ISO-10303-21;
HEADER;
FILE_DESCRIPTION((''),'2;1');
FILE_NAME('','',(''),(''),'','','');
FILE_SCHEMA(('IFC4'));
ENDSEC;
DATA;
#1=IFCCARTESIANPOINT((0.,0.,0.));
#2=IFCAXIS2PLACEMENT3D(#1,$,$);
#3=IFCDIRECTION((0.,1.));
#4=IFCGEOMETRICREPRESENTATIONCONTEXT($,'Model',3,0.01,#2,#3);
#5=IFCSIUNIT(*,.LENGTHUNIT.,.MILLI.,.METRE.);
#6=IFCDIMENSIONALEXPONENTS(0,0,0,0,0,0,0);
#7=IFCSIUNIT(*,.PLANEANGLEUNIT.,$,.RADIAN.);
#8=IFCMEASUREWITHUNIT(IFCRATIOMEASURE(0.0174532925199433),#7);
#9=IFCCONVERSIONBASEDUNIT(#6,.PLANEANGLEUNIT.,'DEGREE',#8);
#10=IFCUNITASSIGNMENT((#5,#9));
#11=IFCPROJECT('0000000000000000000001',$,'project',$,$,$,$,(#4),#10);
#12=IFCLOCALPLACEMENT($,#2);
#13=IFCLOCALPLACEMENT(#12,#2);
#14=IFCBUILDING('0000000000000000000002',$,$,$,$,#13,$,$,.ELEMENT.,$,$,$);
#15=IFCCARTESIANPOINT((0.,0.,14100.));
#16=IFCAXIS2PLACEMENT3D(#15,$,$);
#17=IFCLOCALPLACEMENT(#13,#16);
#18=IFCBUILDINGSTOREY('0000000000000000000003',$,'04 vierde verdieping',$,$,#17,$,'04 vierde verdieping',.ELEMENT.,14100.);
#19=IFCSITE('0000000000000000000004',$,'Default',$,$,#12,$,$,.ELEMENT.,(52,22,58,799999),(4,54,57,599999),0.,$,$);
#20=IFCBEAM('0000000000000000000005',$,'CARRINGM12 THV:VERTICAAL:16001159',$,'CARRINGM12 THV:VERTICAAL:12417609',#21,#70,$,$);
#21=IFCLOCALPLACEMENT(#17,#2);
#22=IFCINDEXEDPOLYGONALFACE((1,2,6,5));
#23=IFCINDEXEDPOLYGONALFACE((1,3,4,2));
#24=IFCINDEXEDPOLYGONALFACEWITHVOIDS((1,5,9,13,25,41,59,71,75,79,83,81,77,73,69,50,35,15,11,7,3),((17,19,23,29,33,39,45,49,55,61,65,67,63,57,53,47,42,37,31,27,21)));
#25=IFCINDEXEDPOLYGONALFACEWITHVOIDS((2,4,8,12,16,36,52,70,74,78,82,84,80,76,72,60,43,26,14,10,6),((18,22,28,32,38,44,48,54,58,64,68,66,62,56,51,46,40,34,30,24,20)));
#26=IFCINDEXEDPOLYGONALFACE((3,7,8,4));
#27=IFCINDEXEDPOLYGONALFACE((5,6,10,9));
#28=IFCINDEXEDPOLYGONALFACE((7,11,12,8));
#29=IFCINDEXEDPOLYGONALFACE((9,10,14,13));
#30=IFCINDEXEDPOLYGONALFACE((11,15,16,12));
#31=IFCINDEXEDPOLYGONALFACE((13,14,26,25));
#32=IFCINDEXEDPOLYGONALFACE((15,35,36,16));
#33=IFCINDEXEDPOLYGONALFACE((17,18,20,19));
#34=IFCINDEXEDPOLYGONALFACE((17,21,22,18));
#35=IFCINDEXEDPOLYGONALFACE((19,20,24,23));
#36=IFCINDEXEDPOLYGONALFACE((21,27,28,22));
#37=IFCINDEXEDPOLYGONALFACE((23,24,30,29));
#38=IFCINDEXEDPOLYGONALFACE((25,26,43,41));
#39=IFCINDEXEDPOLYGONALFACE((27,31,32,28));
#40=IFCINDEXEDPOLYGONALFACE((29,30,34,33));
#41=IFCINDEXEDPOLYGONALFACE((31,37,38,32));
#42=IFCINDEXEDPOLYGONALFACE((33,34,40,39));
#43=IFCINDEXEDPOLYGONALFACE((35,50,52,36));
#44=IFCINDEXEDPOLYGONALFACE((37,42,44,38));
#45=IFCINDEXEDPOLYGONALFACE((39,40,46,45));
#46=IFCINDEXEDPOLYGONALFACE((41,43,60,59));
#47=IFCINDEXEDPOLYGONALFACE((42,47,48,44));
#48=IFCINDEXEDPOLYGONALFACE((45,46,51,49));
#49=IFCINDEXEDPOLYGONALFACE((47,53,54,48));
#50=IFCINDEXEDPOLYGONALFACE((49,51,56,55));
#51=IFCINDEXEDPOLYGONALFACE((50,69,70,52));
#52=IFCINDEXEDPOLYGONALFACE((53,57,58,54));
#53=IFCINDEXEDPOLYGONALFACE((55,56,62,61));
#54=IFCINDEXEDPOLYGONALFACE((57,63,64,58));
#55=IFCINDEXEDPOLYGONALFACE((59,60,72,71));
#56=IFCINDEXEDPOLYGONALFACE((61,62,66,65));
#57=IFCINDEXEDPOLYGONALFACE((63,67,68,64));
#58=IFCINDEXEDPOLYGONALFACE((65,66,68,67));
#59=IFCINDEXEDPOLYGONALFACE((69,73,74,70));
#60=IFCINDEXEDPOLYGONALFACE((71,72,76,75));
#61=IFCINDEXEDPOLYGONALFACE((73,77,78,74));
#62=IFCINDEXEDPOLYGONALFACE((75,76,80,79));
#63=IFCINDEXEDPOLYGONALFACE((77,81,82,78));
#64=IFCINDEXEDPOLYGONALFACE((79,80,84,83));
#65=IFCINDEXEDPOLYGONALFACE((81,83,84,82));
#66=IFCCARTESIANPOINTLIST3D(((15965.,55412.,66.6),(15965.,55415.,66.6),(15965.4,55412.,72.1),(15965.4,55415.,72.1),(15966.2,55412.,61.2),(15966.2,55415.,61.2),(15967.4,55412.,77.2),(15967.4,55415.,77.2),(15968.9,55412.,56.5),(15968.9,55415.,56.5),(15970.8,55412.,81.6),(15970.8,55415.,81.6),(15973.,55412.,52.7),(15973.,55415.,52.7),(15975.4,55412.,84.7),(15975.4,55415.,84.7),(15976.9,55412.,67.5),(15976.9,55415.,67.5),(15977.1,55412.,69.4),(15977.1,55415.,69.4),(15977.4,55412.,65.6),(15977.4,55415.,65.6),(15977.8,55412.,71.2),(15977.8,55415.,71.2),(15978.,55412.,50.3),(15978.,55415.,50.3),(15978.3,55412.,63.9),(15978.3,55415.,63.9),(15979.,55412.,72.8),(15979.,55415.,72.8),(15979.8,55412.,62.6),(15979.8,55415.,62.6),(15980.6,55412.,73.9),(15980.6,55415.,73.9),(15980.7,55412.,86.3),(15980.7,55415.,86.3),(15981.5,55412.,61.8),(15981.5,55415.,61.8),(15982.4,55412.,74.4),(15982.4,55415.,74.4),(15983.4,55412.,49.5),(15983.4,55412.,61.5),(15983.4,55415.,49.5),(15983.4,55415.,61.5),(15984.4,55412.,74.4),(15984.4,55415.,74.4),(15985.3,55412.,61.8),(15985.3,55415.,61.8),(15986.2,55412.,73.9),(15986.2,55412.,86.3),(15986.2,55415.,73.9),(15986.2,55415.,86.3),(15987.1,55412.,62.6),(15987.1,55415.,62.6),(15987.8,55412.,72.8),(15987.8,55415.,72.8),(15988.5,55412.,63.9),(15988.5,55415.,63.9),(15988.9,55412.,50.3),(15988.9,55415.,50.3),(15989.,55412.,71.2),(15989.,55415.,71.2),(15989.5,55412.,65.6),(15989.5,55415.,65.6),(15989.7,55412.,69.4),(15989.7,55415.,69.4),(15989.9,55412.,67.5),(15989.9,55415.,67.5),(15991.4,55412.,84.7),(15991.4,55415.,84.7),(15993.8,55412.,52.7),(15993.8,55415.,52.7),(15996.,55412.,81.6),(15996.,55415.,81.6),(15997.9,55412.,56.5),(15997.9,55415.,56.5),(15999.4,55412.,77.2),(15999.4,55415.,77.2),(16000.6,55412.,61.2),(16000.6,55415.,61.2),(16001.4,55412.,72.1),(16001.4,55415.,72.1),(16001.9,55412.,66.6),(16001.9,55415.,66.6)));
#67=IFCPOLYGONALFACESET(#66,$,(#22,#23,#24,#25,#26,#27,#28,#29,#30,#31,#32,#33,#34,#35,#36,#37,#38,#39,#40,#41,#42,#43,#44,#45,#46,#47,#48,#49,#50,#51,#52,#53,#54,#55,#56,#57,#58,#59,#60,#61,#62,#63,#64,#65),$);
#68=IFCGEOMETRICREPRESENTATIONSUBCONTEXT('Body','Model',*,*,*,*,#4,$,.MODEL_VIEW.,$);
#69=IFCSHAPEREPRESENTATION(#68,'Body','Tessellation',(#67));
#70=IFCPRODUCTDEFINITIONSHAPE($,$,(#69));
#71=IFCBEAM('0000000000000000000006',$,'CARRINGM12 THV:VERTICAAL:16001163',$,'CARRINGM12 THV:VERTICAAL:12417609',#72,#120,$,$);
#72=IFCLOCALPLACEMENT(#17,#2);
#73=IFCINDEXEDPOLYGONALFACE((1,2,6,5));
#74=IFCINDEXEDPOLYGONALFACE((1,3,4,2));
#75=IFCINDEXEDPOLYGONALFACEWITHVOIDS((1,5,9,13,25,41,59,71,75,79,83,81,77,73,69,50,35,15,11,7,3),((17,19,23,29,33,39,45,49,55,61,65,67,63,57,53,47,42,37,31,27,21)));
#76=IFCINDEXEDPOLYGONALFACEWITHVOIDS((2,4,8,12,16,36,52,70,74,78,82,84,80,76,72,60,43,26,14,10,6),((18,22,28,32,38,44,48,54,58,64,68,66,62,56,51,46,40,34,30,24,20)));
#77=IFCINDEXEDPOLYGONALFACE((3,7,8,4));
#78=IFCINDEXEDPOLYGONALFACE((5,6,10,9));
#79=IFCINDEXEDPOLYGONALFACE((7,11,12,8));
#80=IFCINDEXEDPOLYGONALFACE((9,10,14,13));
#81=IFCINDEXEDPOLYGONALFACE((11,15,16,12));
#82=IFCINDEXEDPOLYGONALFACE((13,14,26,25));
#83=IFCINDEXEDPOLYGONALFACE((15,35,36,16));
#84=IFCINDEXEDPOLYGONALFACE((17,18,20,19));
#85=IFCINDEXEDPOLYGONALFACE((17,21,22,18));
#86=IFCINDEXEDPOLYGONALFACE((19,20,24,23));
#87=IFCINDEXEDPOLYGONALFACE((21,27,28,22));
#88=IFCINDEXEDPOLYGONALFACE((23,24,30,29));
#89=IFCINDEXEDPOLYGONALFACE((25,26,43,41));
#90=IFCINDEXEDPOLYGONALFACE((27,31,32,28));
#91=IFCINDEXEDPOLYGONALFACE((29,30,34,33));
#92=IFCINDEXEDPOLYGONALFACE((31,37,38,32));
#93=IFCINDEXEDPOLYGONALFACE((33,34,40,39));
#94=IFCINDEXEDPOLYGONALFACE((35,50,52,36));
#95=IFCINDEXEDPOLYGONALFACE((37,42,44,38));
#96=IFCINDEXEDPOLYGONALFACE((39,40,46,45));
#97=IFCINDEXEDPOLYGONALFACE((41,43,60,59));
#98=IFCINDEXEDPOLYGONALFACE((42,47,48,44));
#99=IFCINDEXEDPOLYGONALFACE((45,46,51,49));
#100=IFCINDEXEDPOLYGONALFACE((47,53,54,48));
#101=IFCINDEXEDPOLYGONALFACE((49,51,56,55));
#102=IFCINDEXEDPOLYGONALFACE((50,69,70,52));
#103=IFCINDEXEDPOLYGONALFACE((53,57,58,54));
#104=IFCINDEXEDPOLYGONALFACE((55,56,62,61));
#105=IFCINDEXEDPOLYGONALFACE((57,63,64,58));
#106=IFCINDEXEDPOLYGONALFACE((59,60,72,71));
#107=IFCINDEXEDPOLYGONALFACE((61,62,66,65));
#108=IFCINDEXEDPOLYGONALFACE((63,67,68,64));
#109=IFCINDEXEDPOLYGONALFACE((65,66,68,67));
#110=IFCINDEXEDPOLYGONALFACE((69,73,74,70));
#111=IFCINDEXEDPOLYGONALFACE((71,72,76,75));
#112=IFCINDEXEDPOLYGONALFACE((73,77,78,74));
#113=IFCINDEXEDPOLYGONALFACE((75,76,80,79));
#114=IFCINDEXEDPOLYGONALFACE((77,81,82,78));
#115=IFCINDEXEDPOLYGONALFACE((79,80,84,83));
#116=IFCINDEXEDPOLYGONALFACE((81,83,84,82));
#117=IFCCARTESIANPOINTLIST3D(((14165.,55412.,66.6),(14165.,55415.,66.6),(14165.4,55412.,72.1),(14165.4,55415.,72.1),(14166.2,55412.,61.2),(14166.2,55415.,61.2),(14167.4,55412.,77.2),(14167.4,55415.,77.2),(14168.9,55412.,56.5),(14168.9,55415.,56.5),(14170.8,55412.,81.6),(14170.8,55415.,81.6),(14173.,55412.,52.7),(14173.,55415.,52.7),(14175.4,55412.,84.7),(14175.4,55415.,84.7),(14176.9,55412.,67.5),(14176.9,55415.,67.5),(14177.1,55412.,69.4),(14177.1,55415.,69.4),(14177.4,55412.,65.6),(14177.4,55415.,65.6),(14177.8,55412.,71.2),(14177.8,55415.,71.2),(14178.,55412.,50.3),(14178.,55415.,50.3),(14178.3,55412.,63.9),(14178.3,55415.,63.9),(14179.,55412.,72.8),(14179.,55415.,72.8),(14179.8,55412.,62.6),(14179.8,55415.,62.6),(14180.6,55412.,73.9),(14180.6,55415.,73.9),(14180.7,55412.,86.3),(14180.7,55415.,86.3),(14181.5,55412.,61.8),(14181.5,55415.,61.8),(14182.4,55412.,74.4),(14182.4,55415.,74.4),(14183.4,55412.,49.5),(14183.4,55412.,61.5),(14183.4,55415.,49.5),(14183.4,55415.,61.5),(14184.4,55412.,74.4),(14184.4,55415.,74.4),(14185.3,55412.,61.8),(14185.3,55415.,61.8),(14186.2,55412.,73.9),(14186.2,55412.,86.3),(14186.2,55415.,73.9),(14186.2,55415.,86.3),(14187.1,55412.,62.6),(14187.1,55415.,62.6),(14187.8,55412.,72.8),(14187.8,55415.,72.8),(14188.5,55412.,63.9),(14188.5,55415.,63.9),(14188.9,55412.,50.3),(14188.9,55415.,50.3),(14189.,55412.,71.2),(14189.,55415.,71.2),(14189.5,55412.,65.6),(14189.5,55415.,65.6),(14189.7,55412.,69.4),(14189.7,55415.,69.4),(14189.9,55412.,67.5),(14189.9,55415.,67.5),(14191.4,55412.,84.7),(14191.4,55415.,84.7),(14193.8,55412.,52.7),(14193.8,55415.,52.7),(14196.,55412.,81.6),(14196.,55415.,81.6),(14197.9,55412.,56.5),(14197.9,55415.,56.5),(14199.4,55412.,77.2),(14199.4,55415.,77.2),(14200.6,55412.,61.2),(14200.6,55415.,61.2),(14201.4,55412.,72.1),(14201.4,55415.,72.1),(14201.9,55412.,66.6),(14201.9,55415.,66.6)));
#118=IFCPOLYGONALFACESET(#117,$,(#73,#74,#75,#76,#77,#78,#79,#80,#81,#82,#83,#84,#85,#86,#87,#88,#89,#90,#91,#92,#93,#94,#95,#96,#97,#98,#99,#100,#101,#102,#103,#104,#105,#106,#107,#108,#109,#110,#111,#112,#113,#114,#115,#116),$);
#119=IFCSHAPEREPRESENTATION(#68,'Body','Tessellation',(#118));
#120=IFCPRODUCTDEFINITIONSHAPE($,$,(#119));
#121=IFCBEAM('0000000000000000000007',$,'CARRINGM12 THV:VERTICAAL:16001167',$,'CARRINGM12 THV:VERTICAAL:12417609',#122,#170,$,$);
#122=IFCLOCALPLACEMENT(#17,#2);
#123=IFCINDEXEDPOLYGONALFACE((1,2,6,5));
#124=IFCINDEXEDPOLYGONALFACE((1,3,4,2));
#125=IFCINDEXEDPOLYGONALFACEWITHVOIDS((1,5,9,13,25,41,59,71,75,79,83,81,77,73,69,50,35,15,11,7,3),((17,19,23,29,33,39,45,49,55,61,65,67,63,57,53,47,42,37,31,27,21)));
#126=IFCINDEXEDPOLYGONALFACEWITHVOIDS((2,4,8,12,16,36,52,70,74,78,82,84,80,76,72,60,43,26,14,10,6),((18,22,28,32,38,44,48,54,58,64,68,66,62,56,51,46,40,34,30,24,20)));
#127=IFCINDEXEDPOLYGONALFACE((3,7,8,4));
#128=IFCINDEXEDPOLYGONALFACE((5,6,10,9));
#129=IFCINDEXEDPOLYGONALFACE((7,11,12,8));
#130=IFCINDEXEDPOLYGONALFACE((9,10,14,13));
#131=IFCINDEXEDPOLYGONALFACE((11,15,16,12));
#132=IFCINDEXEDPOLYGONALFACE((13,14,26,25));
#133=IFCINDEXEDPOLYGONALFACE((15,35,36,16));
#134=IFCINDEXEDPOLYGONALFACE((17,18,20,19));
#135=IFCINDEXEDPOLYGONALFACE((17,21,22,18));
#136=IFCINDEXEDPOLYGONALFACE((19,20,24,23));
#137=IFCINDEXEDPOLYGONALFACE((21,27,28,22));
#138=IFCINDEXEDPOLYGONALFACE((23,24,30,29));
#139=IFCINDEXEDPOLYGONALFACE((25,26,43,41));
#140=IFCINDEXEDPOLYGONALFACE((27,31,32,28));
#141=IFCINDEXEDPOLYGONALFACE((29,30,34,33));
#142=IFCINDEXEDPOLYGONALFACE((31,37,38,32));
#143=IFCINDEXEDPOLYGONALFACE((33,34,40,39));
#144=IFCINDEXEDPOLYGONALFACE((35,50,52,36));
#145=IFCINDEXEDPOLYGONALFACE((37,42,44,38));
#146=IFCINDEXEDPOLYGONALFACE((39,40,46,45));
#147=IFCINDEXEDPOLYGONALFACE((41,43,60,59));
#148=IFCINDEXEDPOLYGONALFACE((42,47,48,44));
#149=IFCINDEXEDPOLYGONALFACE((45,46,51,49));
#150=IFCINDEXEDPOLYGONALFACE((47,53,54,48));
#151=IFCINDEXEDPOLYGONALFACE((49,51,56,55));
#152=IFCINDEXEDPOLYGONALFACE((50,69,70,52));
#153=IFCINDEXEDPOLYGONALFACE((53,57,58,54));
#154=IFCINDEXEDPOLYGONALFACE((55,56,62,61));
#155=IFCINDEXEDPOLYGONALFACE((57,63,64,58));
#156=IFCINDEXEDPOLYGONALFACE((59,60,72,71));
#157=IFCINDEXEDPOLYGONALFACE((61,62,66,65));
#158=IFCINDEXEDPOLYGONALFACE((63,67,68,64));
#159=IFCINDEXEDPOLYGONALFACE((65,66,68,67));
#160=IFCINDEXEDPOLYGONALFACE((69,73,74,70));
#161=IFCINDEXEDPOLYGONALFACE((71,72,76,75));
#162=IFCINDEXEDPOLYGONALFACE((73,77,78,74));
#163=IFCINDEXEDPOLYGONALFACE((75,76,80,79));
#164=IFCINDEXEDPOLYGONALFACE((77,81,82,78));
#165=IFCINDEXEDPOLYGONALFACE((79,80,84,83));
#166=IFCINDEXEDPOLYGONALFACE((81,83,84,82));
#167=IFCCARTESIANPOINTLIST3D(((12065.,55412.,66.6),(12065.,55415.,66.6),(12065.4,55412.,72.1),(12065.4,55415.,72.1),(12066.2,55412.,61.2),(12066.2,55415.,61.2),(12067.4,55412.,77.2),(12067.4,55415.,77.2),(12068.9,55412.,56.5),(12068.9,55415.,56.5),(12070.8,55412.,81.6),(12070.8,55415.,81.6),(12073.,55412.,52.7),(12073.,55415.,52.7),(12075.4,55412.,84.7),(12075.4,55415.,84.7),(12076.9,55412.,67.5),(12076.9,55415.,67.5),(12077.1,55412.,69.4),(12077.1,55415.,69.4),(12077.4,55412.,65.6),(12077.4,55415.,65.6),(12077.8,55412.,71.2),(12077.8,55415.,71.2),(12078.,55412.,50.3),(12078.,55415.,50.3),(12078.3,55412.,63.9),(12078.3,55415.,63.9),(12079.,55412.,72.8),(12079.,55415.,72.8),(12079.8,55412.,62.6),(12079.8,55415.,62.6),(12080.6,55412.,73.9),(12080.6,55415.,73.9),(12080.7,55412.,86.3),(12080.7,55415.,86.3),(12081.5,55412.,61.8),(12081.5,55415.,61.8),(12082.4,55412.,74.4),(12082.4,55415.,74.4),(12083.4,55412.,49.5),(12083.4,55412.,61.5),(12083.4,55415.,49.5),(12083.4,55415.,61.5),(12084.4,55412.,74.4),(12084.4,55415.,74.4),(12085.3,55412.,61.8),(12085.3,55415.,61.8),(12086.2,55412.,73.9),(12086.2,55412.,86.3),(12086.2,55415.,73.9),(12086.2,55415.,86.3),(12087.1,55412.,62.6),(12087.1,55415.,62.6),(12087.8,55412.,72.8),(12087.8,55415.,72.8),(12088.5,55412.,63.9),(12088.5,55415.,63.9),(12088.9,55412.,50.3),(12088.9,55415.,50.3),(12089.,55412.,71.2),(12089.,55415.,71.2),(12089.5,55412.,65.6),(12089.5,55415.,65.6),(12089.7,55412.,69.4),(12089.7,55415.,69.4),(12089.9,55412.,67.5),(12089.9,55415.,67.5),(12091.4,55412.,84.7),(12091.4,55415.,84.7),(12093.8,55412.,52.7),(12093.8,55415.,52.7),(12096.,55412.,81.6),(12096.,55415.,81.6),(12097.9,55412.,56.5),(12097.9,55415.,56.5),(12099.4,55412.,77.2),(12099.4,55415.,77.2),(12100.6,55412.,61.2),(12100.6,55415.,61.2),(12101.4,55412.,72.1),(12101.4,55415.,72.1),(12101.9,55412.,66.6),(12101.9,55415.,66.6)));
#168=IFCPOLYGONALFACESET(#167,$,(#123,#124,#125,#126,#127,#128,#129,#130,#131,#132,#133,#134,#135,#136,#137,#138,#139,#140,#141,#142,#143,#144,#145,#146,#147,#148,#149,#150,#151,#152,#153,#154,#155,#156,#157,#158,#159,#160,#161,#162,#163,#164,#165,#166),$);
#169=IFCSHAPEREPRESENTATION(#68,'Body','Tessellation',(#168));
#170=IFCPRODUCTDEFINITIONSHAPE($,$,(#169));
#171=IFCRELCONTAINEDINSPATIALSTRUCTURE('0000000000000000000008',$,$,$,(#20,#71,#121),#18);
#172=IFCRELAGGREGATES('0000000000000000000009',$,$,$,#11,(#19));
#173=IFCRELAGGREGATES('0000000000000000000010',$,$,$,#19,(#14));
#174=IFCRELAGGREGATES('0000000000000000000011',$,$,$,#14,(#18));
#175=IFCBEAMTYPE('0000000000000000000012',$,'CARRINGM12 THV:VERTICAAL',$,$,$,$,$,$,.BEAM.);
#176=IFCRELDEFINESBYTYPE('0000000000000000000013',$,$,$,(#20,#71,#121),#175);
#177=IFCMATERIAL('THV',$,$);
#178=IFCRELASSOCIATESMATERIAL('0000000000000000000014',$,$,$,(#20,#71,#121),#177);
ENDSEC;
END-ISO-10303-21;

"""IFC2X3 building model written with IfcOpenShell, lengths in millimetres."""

from ifc_helpers import new_model, entity, si_unit, converted_unit, direction, frame, origin, origin_2d_with_axis, place, context, subcontext, project, spatial, hollow_circle, extrude, material, type_object, element, save


model = new_model("IFC2X3")

# Units and contexts
model_context = context("Model", 3, precision=0.01, world=origin(), true_north=direction((0.0, 1.0)))
body_context = subcontext(model_context, "Body", "Model", "MODEL_VIEW")
ifc_project = project(units=[si_unit("LENGTHUNIT", "METRE", prefix="MILLI"), converted_unit("PLANEANGLEUNIT", "DEGREE", entity("IfcRatioMeasure", 0.0174532925199433), si_unit("PLANEANGLEUNIT", "RADIAN"), dimensions=[0, 0, 0, 0, 0, 0, 0])], contexts=[model_context])

# Site, building, storey
site_placement = place(None, origin())
site = spatial("IfcSite", under=ifc_project, at=site_placement, Name="Default", CompositionType="ELEMENT", RefLatitude=(52, 22, 58, 799999), RefLongitude=(4, 54, 57, 599999), RefElevation=0.0)
building_placement = place(site_placement, origin())
building = spatial("IfcBuilding", under=site, at=building_placement, CompositionType="ELEMENT")
storey_placement = place(building_placement, frame((0.0, 0.0, 14100.0)))
storey = spatial("IfcBuildingStorey", under=building, at=storey_placement, Name="04 vierde verdieping", LongName="04 vierde verdieping", CompositionType="ELEMENT", Elevation=14100.0)

# Beams
ifc_material_1 = material(Name="THV")
beam_type_1 = type_object("IfcBeamType", Name="CARRINGM12 THV:VERTICAAL", PredefinedType="BEAM")
beam_1_placement = place(storey_placement, origin())
element("IfcBeam", 1, at=beam_1_placement, inside=storey, type_object=beam_type_1, material=ifc_material_1, Name="CARRINGM12 THV:VERTICAAL:16001159", ObjectType="CARRINGM12 THV:VERTICAAL:12417609", context=body_context, shape_type="SweptSolid", body=[
    extrude(hollow_circle(Radius=18.5, WallThickness=12.0, at=origin_2d_with_axis()), frame((15983.4, 55412.0, 68.0), z_axis=(0.0, 1.0, 0.0), x_axis=(0.0, 0.0, -1.0)), (0.0, 0.0, 1.0), 3.0),
])
beam_2_placement = place(storey_placement, origin())
element("IfcBeam", 2, at=beam_2_placement, inside=storey, type_object=beam_type_1, material=ifc_material_1, Name="CARRINGM12 THV:VERTICAAL:16001163", ObjectType="CARRINGM12 THV:VERTICAAL:12417609", context=body_context, shape_type="SweptSolid", body=[
    extrude(hollow_circle(Radius=18.5, WallThickness=12.0, at=origin_2d_with_axis()), frame((14183.4, 55412.0, 68.0), z_axis=(0.0, 1.0, 0.0), x_axis=(0.0, 0.0, -1.0)), (0.0, 0.0, 1.0), 3.0),
])
beam_3_placement = place(storey_placement, origin())
element("IfcBeam", 3, at=beam_3_placement, inside=storey, type_object=beam_type_1, material=ifc_material_1, Name="CARRINGM12 THV:VERTICAAL:16001167", ObjectType="CARRINGM12 THV:VERTICAAL:12417609", context=body_context, shape_type="SweptSolid", body=[
    extrude(hollow_circle(Radius=18.5, WallThickness=12.0, at=origin_2d_with_axis()), frame((12083.4, 55412.0, 68.0), z_axis=(0.0, 1.0, 0.0), x_axis=(0.0, 0.0, -1.0)), (0.0, 0.0, 1.0), 3.0),
])

save(model, "model.ifc")
